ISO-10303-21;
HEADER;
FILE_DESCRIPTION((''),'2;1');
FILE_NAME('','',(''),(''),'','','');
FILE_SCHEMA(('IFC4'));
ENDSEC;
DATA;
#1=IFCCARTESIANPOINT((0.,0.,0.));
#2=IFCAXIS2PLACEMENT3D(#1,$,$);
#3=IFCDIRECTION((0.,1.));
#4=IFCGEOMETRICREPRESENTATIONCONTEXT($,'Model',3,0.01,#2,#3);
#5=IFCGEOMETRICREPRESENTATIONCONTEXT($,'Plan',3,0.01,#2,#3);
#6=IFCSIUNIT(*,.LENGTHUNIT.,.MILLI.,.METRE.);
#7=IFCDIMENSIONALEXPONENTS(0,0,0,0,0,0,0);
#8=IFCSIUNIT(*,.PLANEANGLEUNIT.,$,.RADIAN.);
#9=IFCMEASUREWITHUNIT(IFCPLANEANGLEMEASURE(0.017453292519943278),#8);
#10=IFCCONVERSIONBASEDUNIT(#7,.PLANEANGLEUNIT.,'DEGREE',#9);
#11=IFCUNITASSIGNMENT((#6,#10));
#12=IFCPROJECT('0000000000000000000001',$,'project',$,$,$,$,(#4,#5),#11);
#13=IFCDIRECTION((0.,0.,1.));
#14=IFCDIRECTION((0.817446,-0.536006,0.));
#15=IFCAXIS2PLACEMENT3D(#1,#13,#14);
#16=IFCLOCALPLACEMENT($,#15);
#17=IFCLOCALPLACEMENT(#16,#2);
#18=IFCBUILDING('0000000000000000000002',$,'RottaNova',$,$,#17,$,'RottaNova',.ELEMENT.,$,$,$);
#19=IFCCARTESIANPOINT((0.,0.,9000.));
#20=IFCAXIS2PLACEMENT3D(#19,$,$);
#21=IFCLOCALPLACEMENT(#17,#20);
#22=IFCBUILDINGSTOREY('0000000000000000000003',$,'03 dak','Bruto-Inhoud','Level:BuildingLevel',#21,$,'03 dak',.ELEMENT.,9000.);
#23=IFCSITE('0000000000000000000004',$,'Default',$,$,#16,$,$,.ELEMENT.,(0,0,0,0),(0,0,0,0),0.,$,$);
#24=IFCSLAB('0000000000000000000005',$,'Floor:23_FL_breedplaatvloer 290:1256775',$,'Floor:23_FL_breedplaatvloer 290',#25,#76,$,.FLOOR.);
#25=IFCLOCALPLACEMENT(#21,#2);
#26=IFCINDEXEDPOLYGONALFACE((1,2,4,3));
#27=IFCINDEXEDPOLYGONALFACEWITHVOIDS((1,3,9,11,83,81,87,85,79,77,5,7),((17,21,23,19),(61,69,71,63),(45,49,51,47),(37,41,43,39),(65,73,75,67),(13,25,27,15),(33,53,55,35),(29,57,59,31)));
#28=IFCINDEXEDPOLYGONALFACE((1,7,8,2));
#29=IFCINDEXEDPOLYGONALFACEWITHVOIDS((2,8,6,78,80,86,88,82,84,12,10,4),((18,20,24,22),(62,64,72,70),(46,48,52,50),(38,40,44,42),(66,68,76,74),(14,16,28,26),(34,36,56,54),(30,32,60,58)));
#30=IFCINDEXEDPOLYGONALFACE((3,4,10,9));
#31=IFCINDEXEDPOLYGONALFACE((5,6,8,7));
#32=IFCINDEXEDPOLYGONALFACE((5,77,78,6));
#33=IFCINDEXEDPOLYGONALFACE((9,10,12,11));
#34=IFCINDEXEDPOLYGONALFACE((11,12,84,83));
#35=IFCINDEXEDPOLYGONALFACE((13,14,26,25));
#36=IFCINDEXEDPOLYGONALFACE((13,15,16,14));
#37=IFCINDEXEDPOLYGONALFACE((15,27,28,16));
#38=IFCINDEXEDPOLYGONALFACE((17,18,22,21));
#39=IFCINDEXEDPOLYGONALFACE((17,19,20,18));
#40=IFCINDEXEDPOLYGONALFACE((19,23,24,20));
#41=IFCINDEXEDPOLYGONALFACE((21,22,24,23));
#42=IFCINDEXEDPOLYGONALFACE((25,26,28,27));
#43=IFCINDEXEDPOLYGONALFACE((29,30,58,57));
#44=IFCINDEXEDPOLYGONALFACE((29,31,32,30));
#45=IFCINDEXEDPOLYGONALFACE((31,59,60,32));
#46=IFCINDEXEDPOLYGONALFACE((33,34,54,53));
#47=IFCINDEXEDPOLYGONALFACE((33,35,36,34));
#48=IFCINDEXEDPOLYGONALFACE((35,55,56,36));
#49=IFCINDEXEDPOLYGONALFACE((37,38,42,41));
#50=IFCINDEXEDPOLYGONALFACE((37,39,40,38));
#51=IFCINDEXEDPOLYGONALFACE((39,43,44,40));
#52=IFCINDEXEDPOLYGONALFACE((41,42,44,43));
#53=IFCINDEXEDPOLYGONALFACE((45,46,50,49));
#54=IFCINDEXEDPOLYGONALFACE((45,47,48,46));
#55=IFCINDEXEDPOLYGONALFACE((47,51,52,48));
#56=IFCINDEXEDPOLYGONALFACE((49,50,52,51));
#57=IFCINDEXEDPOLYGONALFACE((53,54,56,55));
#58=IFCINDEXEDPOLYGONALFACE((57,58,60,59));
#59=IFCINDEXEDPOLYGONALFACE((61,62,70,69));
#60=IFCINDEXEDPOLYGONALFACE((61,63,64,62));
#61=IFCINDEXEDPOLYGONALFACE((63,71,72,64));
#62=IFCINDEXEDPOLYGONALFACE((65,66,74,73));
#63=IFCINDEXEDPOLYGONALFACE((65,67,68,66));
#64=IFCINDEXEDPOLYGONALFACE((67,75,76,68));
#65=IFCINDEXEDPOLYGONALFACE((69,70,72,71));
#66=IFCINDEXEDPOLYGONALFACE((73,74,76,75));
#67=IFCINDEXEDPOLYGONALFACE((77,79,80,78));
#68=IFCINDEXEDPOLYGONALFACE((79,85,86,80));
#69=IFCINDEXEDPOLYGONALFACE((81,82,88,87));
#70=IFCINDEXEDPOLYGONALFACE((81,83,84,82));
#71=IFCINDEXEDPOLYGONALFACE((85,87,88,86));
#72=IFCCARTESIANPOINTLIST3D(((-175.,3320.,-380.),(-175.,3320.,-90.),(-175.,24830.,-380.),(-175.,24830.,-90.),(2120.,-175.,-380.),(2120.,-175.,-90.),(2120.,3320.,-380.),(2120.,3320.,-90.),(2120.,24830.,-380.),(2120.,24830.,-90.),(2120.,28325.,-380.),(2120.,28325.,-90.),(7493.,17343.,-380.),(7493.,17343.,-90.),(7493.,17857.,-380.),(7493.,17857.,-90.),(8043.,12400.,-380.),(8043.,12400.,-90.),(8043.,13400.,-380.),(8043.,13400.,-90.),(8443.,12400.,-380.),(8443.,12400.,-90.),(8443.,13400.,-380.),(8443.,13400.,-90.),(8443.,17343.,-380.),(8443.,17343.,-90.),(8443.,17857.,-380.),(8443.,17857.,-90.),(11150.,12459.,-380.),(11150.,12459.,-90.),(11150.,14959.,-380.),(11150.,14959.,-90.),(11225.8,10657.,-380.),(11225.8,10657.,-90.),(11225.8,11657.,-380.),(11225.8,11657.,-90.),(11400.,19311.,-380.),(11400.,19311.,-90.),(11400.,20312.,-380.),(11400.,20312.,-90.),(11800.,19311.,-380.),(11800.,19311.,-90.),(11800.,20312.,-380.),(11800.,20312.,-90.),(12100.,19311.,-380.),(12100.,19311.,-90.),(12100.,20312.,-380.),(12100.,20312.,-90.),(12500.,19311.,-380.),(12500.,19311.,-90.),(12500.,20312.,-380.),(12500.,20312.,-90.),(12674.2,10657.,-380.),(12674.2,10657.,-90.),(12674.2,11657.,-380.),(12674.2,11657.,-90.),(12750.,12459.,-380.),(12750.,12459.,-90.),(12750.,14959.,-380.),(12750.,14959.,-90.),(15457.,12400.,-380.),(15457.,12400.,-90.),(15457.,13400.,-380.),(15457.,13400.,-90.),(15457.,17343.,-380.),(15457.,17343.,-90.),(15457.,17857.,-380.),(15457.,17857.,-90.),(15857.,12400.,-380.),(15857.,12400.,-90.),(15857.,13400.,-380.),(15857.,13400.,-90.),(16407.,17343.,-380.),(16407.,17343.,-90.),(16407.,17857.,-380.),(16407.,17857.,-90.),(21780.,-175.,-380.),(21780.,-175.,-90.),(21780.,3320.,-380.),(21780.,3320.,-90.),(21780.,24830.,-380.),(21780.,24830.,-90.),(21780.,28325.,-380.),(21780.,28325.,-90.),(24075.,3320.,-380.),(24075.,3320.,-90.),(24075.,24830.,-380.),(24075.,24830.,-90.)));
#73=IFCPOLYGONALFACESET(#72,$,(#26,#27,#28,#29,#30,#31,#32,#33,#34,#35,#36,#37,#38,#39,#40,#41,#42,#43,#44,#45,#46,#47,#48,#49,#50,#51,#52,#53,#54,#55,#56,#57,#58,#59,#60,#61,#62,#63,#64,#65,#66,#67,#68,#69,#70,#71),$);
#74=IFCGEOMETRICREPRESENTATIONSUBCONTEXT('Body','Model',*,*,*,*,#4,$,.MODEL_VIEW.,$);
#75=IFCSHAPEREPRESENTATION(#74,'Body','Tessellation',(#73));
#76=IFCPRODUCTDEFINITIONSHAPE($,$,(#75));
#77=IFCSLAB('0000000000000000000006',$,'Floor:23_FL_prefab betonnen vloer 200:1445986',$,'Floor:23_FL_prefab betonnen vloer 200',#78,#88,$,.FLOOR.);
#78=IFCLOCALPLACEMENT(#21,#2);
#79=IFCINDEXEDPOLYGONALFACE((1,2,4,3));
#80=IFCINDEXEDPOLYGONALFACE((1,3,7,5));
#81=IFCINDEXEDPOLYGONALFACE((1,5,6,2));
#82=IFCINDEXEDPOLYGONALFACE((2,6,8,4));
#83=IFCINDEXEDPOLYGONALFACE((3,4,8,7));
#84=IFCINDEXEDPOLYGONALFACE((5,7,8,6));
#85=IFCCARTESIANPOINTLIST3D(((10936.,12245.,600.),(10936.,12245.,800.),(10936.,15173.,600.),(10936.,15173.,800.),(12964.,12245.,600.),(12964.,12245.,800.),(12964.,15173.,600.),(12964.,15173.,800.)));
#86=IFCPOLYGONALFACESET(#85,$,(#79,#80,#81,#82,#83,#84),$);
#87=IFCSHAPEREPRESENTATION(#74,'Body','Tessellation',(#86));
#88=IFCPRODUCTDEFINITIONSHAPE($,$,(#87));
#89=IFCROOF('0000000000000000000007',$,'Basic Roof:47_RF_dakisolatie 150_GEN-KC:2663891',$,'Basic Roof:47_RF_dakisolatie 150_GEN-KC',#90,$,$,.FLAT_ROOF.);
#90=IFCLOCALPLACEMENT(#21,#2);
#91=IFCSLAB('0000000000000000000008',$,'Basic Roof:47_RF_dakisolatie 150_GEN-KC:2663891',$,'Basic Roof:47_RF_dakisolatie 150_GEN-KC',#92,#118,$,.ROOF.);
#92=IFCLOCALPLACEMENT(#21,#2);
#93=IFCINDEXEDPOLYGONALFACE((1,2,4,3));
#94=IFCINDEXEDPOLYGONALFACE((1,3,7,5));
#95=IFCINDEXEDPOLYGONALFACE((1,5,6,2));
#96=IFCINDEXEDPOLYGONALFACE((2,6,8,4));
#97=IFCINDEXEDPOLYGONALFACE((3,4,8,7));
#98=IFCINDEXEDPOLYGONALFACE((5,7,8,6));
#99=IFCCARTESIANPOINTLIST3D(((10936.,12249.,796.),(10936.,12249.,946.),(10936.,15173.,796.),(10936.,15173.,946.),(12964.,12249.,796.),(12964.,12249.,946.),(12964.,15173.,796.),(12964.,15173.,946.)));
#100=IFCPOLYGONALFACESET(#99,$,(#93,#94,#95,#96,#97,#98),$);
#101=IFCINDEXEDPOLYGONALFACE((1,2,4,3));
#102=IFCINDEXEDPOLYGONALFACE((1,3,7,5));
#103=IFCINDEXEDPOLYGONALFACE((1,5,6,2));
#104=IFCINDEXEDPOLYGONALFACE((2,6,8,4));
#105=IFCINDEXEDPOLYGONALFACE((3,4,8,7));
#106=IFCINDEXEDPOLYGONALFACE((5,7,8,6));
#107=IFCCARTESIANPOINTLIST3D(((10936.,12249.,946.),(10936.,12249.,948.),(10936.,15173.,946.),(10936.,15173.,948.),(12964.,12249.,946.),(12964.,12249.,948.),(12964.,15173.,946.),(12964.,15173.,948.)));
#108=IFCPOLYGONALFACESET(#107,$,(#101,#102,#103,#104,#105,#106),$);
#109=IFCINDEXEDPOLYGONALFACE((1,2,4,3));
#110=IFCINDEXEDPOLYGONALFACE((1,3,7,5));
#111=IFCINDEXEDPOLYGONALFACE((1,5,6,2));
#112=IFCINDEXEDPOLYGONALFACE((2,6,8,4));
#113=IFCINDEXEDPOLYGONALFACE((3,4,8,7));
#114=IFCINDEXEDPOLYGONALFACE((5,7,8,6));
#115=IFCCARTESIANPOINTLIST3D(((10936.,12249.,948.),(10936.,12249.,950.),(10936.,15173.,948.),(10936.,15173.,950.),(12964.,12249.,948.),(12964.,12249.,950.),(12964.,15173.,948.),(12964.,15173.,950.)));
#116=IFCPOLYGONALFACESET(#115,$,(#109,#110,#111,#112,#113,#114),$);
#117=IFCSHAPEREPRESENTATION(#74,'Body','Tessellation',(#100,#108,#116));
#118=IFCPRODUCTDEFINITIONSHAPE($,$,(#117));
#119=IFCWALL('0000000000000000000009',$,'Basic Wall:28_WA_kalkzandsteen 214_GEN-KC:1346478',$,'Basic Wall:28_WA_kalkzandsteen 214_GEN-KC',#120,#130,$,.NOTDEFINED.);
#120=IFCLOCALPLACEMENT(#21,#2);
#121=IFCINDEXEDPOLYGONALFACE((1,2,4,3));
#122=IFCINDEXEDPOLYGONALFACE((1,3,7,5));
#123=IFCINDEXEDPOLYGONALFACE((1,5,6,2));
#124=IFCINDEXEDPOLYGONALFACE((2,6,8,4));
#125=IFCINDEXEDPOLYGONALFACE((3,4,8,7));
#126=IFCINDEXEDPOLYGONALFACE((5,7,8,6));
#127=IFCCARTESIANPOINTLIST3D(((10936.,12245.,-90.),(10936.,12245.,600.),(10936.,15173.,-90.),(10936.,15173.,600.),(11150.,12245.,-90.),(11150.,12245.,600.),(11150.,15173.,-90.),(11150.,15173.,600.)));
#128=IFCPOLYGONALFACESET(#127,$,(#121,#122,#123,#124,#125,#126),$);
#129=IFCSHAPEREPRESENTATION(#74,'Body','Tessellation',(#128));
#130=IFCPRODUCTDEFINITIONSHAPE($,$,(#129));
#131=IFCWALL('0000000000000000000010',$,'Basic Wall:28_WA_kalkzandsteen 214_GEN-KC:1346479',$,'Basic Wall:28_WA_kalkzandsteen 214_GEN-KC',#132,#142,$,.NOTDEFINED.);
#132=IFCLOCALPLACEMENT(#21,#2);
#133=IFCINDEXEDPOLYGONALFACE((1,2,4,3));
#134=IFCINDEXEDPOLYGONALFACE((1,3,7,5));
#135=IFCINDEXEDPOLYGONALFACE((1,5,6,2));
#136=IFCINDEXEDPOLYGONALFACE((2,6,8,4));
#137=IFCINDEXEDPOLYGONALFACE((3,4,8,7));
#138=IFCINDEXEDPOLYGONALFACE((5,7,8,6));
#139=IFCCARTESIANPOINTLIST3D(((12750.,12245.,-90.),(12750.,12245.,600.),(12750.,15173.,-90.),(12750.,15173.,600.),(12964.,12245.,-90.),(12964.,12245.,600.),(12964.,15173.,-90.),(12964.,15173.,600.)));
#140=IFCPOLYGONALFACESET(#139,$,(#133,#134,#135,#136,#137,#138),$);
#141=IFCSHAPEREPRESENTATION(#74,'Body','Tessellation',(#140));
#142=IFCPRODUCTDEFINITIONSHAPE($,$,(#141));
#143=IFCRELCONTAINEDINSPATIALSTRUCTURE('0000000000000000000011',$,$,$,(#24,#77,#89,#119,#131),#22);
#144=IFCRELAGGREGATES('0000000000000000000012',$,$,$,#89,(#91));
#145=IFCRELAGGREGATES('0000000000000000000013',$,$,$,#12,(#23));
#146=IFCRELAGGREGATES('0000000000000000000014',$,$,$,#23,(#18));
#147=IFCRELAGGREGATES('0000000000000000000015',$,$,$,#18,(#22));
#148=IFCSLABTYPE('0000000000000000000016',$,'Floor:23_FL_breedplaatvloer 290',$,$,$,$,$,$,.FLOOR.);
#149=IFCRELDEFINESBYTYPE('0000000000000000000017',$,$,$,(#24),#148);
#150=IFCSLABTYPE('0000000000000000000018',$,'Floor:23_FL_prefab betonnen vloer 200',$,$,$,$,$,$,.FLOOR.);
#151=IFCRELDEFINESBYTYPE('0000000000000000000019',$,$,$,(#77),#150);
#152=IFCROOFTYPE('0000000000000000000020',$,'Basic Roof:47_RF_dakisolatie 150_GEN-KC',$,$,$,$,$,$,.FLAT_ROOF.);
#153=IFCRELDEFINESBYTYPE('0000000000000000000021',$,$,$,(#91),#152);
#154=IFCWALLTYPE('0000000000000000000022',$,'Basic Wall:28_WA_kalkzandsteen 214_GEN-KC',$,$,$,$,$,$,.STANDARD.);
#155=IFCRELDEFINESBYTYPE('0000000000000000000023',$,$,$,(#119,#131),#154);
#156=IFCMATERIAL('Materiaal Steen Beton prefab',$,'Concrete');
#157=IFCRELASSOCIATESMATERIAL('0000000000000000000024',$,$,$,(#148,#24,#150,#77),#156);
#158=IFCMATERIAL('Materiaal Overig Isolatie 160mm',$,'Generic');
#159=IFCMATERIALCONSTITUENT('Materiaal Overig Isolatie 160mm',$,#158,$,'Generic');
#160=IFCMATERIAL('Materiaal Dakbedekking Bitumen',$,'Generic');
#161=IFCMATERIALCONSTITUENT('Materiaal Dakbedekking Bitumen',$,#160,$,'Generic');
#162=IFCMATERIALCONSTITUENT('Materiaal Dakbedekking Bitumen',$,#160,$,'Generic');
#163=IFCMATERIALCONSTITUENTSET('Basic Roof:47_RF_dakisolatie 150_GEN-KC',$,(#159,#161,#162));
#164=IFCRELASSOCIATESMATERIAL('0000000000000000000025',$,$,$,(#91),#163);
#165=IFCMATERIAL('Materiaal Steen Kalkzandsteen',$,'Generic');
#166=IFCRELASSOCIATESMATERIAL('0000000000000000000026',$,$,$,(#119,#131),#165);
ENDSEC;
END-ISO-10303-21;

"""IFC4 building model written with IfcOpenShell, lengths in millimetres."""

from ifc_helpers import new_model, entity, si_unit, converted_unit, direction, frame, origin, place, context, subcontext, project, spatial, indexed_curve, outline, extrude, material, constituent, constituent_set, type_object, element, aggregate, save


model = new_model("IFC4")

# Units and contexts
model_context = context("Model", 3, precision=0.01, world=origin(), true_north=direction((0.0, 1.0)))
plan_context = context("Plan", 3, precision=0.01, world=origin(), true_north=direction((0.0, 1.0)))
body_context = subcontext(model_context, "Body", "Model", "MODEL_VIEW")
ifc_project = project(units=[si_unit("LENGTHUNIT", "METRE", prefix="MILLI"), converted_unit("PLANEANGLEUNIT", "DEGREE", entity("IfcPlaneAngleMeasure", 0.017453292519943278), si_unit("PLANEANGLEUNIT", "RADIAN"), dimensions=[0, 0, 0, 0, 0, 0, 0])], contexts=[model_context, plan_context])

# Site, building, storey
site_placement = place(None, frame((0.0, 0.0, 0.0), z_axis=(0.0, 0.0, 1.0), x_axis=(0.817446, -0.536006, 0.0)))
site = spatial("IfcSite", under=ifc_project, at=site_placement, Name="Default", CompositionType="ELEMENT", RefLatitude=(0, 0, 0, 0), RefLongitude=(0, 0, 0, 0), RefElevation=0.0)
building_placement = place(site_placement, origin())
building = spatial("IfcBuilding", under=site, at=building_placement, Name="RottaNova", LongName="RottaNova", CompositionType="ELEMENT")
storey_placement = place(building_placement, frame((0.0, 0.0, 9000.0)))
storey = spatial("IfcBuildingStorey", under=building, at=storey_placement, Name="03 dak", Description="Bruto-Inhoud", ObjectType="Level:BuildingLevel", LongName="03 dak", CompositionType="ELEMENT", Elevation=9000.0)

# Slab, openings
ifc_material_1 = material(Name="Materiaal Steen Beton prefab", Category="Concrete")
slab_type_1 = type_object("IfcSlabType", Name="Floor:23_FL_breedplaatvloer 290", PredefinedType="FLOOR", material=ifc_material_1)
slab_1_placement = place(storey_placement, origin())
slab_1 = element("IfcSlab", 1, at=slab_1_placement, inside=storey, type_object=slab_type_1, material=ifc_material_1, Name="Floor:23_FL_breedplaatvloer 290:1256775", ObjectType="Floor:23_FL_breedplaatvloer 290", PredefinedType="FLOOR", context=body_context, shape_type="SweptSolid", body=[
    extrude(outline(indexed_curve([(-12125.0, 10755.0), (-12125.0, -10755.0), (-9830.0, -10755.0), (-9830.0, -14250.0), (9830.0, -14250.0), (9830.0, -10755.0), (12125.0, -10755.0), (12125.0, 10755.0), (9830.0, 10755.0), (9830.0, 14250.0), (-9830.0, 14250.0), (-9830.0, 10755.0), (-12125.0, 10755.0)], self_intersect=False), holes=[indexed_curve([(-800.0, 884.0), (800.0, 884.0), (800.0, -1616.0), (-800.0, -1616.0), (-800.0, 884.0)], self_intersect=False), indexed_curve([(724.2, -2418.0), (724.2, -3418.0), (-724.2, -3418.0), (-724.2, -2418.0), (724.2, -2418.0)], self_intersect=False), indexed_curve([(-4457.0, 3782.0), (-3507.0, 3782.0), (-3507.0, 3268.0), (-4457.0, 3268.0), (-4457.0, 3782.0)], self_intersect=False), indexed_curve([(-550.0, 6237.0), (-150.0, 6237.0), (-150.0, 5236.0), (-550.0, 5236.0), (-550.0, 6237.0)], self_intersect=False), indexed_curve([(-3907.0, -675.0), (-3507.0, -675.0), (-3507.0, -1675.0), (-3907.0, -1675.0), (-3907.0, -675.0)], self_intersect=False), indexed_curve([(3907.0, -675.0), (3907.0, -1675.0), (3507.0, -1675.0), (3507.0, -675.0), (3907.0, -675.0)], self_intersect=False), indexed_curve([(550.0, 6237.0), (550.0, 5236.0), (150.0, 5236.0), (150.0, 6237.0), (550.0, 6237.0)], self_intersect=False), indexed_curve([(4457.0, 3782.0), (4457.0, 3268.0), (3507.0, 3268.0), (3507.0, 3782.0), (4457.0, 3782.0)], self_intersect=False)]), frame((11950.0, 14075.0, -380.0), z_axis=(0.0, 0.0, -1.0), x_axis=(-1.0, 0.0, 0.0)), (0.0, 0.0, -1.0), 290.0),
])
opening_1_placement = place(slab_1_placement, origin())
element("IfcOpeningElement", 2, at=opening_1_placement, cuts=slab_1, PredefinedType="OPENING", context=body_context, shape_type="SweptSolid", body=[
    extrude(outline(indexed_curve([(-475.0, -257.0), (475.0, -257.0), (475.0, 257.0), (-475.0, 257.0), (-475.0, -257.0)], self_intersect=False)), frame((15932.0, 17600.0, -380.0), z_axis=(0.0, 0.0, 1.0), x_axis=(-1.0, 0.0, 0.0)), (0.0, 0.0, 1.0), 290.0),
])
opening_2_placement = place(slab_1_placement, origin())
element("IfcOpeningElement", 3, at=opening_2_placement, cuts=slab_1, PredefinedType="OPENING", context=body_context, shape_type="SweptSolid", body=[
    extrude(outline(indexed_curve([(-200.0, -500.5), (200.0, -500.5), (200.0, 500.5), (-200.0, 500.5), (-200.0, -500.5)], self_intersect=False)), frame((12300.0, 19811.5, -380.0), z_axis=(0.0, 0.0, 1.0), x_axis=(-1.0, 0.0, 0.0)), (0.0, 0.0, 1.0), 290.0),
])
opening_3_placement = place(slab_1_placement, origin())
element("IfcOpeningElement", 4, at=opening_3_placement, cuts=slab_1, PredefinedType="OPENING", context=body_context, shape_type="SweptSolid", body=[
    extrude(outline(indexed_curve([(-200.0, -500.0), (200.0, -500.0), (200.0, 500.0), (-200.0, 500.0), (-200.0, -500.0)], self_intersect=False)), frame((15657.0, 12900.0, -380.0), z_axis=(0.0, 0.0, 1.0), x_axis=(-1.0, 0.0, 0.0)), (0.0, 0.0, 1.0), 290.0),
])
opening_4_placement = place(slab_1_placement, origin())
element("IfcOpeningElement", 5, at=opening_4_placement, cuts=slab_1, PredefinedType="OPENING", context=body_context, shape_type="SweptSolid", body=[
    extrude(outline(indexed_curve([(-500.0, -200.0), (500.0, -200.0), (500.0, 200.0), (-500.0, 200.0), (-500.0, -200.0)], self_intersect=False)), frame((8243.0, 12900.0, -380.0), z_axis=(0.0, 0.0, 1.0), x_axis=(0.0, -1.0, 0.0)), (0.0, 0.0, 1.0), 290.0),
])
opening_5_placement = place(slab_1_placement, origin())
element("IfcOpeningElement", 6, at=opening_5_placement, cuts=slab_1, PredefinedType="OPENING", context=body_context, shape_type="SweptSolid", body=[
    extrude(outline(indexed_curve([(-500.5, -200.0), (500.5, -200.0), (500.5, 200.0), (-500.5, 200.0), (-500.5, -200.0)], self_intersect=False)), frame((11600.0, 19811.5, -380.0), z_axis=(0.0, 0.0, 1.0), x_axis=(0.0, -1.0, 0.0)), (0.0, 0.0, 1.0), 290.0),
])
opening_6_placement = place(slab_1_placement, origin())
element("IfcOpeningElement", 7, at=opening_6_placement, cuts=slab_1, PredefinedType="OPENING", context=body_context, shape_type="SweptSolid", body=[
    extrude(outline(indexed_curve([(-257.0, -475.0), (257.0, -475.0), (257.0, 475.0), (-257.0, 475.0), (-257.0, -475.0)], self_intersect=False)), frame((7968.0, 17600.0, -380.0), z_axis=(0.0, 0.0, 1.0), x_axis=(0.0, -1.0, 0.0)), (0.0, 0.0, 1.0), 290.0),
])
opening_7_placement = place(slab_1_placement, origin())
element("IfcOpeningElement", 8, at=opening_7_placement, cuts=slab_1, PredefinedType="OPENING", context=body_context, shape_type="SweptSolid", body=[
    extrude(outline(indexed_curve([(-1250.0, -800.0), (1250.0, -800.0), (1250.0, 800.0), (-1250.0, 800.0), (-1250.0, -800.0)], self_intersect=False)), frame((11950.0, 13709.0, -90.0), z_axis=(0.0, 0.0, -1.0), x_axis=(0.0, -1.0, 0.0)), (0.0, 0.0, 1.0), 290.0),
])
opening_8_placement = place(slab_1_placement, origin())
element("IfcOpeningElement", 9, at=opening_8_placement, cuts=slab_1, PredefinedType="OPENING", context=body_context, shape_type="SweptSolid", body=[
    extrude(outline(indexed_curve([(-724.2, -500.0), (724.2, -500.0), (724.2, 500.0), (-724.2, 500.0), (-724.2, -500.0)], self_intersect=False)), frame((11950.0, 11157.0, -90.0), z_axis=(0.0, 0.0, -1.0), x_axis=(1.0, 0.0, 0.0)), (0.0, 0.0, 1.0), 290.0),
])

# Slab
slab_type_2 = type_object("IfcSlabType", Name="Floor:23_FL_prefab betonnen vloer 200", PredefinedType="FLOOR", material=ifc_material_1)
slab_2_placement = place(storey_placement, origin())
element("IfcSlab", 10, at=slab_2_placement, inside=storey, type_object=slab_type_2, material=ifc_material_1, Name="Floor:23_FL_prefab betonnen vloer 200:1445986", ObjectType="Floor:23_FL_prefab betonnen vloer 200", PredefinedType="FLOOR", context=body_context, shape_type="SweptSolid", body=[
    extrude(outline(indexed_curve([(-1464.0, -1014.0), (1464.0, -1014.0), (1464.0, 1014.0), (-1464.0, 1014.0), (-1464.0, -1014.0)], self_intersect=False)), frame((11950.0, 13709.0, 800.0), z_axis=(0.0, 0.0, -1.0), x_axis=(0.0, 1.0, 0.0)), (0.0, 0.0, 1.0), 200.0),
])

# Roof, slab
roof_placement = place(storey_placement, frame((10936.0, 12249.0, 796.0)))
roof = element("IfcRoof", 11, at=roof_placement, inside=storey, Name="Basic Roof:47_RF_dakisolatie 150_GEN-KC:2663891", ObjectType="Basic Roof:47_RF_dakisolatie 150_GEN-KC", PredefinedType="FLAT_ROOF")
ifc_material_2 = material(Name="Materiaal Overig Isolatie 160mm", Category="Generic")
ifc_constituent_1 = constituent(ifc_material_2, Name="Materiaal Overig Isolatie 160mm", Category="Generic")
ifc_material_3 = material(Name="Materiaal Dakbedekking Bitumen", Category="Generic")
ifc_constituent_2 = constituent(ifc_material_3, Name="Materiaal Dakbedekking Bitumen", Category="Generic")
ifc_constituent_3 = constituent(ifc_material_3, Name="Materiaal Dakbedekking Bitumen", Category="Generic")
ifc_constituent_set_1 = constituent_set(constituents=[ifc_constituent_1, ifc_constituent_2, ifc_constituent_3], Name="Basic Roof:47_RF_dakisolatie 150_GEN-KC")
roof_type = type_object("IfcRoofType", Name="Basic Roof:47_RF_dakisolatie 150_GEN-KC", PredefinedType="FLAT_ROOF")
slab_3_placement = place(roof_placement, origin())
slab_3 = element("IfcSlab", 12, at=slab_3_placement, type_object=roof_type, material=ifc_constituent_set_1, Name="Basic Roof:47_RF_dakisolatie 150_GEN-KC:2663891", ObjectType="Basic Roof:47_RF_dakisolatie 150_GEN-KC", PredefinedType="ROOF", context=body_context, shape_type="SweptSolid", body=[
    extrude(outline(indexed_curve([(1014.0, 1462.0), (-1014.0, 1462.0), (-1014.0, -1462.0), (1014.0, -1462.0), (1014.0, 1462.0)], self_intersect=False)), frame((1014.0, 1462.0, 0.0)), (0.0, 0.0, 1.0), 150.0),
    extrude(outline(indexed_curve([(1014.0, 1462.0), (-1014.0, 1462.0), (-1014.0, -1462.0), (1014.0, -1462.0), (1014.0, 1462.0)], self_intersect=False)), frame((1014.0, 1462.0, 150.0)), (0.0, 0.0, 1.0), 2.0),
    extrude(outline(indexed_curve([(1014.0, 1462.0), (-1014.0, 1462.0), (-1014.0, -1462.0), (1014.0, -1462.0), (1014.0, 1462.0)], self_intersect=False)), frame((1014.0, 1462.0, 152.0)), (0.0, 0.0, 1.0), 2.0),
])
aggregate(roof, [slab_3])

# Walls
ifc_material_4 = material(Name="Materiaal Steen Kalkzandsteen", Category="Generic")
wall_type_1 = type_object("IfcWallType", Name="Basic Wall:28_WA_kalkzandsteen 214_GEN-KC", PredefinedType="STANDARD")
wall_1_placement = place(storey_placement, frame((11043.0, 12245.0, -90.0), z_axis=(0.0, 0.0, 1.0), x_axis=(0.0, 1.0, 0.0)))
element("IfcWall", 13, at=wall_1_placement, inside=storey, type_object=wall_type_1, material=ifc_material_4, Name="Basic Wall:28_WA_kalkzandsteen 214_GEN-KC:1346478", ObjectType="Basic Wall:28_WA_kalkzandsteen 214_GEN-KC", PredefinedType="NOTDEFINED", context=body_context, shape_type="SweptSolid", body=[
    extrude(outline(indexed_curve([(2928.0, 107.0), (0.0, 107.0), (0.0, -107.0), (2928.0, -107.0), (2928.0, 107.0)], self_intersect=False)), origin(), (0.0, 0.0, 1.0), 690.0),
])
wall_2_placement = place(storey_placement, frame((12857.0, 12245.0, -90.0), z_axis=(0.0, 0.0, 1.0), x_axis=(0.0, 1.0, 0.0)))
element("IfcWall", 14, at=wall_2_placement, inside=storey, type_object=wall_type_1, material=ifc_material_4, Name="Basic Wall:28_WA_kalkzandsteen 214_GEN-KC:1346479", ObjectType="Basic Wall:28_WA_kalkzandsteen 214_GEN-KC", PredefinedType="NOTDEFINED", context=body_context, shape_type="SweptSolid", body=[
    extrude(outline(indexed_curve([(2928.0, 107.0), (0.0, 107.0), (0.0, -107.0), (2928.0, -107.0), (2928.0, 107.0)], self_intersect=False)), origin(), (0.0, 0.0, 1.0), 690.0),
])

save(model, "model.ifc")
